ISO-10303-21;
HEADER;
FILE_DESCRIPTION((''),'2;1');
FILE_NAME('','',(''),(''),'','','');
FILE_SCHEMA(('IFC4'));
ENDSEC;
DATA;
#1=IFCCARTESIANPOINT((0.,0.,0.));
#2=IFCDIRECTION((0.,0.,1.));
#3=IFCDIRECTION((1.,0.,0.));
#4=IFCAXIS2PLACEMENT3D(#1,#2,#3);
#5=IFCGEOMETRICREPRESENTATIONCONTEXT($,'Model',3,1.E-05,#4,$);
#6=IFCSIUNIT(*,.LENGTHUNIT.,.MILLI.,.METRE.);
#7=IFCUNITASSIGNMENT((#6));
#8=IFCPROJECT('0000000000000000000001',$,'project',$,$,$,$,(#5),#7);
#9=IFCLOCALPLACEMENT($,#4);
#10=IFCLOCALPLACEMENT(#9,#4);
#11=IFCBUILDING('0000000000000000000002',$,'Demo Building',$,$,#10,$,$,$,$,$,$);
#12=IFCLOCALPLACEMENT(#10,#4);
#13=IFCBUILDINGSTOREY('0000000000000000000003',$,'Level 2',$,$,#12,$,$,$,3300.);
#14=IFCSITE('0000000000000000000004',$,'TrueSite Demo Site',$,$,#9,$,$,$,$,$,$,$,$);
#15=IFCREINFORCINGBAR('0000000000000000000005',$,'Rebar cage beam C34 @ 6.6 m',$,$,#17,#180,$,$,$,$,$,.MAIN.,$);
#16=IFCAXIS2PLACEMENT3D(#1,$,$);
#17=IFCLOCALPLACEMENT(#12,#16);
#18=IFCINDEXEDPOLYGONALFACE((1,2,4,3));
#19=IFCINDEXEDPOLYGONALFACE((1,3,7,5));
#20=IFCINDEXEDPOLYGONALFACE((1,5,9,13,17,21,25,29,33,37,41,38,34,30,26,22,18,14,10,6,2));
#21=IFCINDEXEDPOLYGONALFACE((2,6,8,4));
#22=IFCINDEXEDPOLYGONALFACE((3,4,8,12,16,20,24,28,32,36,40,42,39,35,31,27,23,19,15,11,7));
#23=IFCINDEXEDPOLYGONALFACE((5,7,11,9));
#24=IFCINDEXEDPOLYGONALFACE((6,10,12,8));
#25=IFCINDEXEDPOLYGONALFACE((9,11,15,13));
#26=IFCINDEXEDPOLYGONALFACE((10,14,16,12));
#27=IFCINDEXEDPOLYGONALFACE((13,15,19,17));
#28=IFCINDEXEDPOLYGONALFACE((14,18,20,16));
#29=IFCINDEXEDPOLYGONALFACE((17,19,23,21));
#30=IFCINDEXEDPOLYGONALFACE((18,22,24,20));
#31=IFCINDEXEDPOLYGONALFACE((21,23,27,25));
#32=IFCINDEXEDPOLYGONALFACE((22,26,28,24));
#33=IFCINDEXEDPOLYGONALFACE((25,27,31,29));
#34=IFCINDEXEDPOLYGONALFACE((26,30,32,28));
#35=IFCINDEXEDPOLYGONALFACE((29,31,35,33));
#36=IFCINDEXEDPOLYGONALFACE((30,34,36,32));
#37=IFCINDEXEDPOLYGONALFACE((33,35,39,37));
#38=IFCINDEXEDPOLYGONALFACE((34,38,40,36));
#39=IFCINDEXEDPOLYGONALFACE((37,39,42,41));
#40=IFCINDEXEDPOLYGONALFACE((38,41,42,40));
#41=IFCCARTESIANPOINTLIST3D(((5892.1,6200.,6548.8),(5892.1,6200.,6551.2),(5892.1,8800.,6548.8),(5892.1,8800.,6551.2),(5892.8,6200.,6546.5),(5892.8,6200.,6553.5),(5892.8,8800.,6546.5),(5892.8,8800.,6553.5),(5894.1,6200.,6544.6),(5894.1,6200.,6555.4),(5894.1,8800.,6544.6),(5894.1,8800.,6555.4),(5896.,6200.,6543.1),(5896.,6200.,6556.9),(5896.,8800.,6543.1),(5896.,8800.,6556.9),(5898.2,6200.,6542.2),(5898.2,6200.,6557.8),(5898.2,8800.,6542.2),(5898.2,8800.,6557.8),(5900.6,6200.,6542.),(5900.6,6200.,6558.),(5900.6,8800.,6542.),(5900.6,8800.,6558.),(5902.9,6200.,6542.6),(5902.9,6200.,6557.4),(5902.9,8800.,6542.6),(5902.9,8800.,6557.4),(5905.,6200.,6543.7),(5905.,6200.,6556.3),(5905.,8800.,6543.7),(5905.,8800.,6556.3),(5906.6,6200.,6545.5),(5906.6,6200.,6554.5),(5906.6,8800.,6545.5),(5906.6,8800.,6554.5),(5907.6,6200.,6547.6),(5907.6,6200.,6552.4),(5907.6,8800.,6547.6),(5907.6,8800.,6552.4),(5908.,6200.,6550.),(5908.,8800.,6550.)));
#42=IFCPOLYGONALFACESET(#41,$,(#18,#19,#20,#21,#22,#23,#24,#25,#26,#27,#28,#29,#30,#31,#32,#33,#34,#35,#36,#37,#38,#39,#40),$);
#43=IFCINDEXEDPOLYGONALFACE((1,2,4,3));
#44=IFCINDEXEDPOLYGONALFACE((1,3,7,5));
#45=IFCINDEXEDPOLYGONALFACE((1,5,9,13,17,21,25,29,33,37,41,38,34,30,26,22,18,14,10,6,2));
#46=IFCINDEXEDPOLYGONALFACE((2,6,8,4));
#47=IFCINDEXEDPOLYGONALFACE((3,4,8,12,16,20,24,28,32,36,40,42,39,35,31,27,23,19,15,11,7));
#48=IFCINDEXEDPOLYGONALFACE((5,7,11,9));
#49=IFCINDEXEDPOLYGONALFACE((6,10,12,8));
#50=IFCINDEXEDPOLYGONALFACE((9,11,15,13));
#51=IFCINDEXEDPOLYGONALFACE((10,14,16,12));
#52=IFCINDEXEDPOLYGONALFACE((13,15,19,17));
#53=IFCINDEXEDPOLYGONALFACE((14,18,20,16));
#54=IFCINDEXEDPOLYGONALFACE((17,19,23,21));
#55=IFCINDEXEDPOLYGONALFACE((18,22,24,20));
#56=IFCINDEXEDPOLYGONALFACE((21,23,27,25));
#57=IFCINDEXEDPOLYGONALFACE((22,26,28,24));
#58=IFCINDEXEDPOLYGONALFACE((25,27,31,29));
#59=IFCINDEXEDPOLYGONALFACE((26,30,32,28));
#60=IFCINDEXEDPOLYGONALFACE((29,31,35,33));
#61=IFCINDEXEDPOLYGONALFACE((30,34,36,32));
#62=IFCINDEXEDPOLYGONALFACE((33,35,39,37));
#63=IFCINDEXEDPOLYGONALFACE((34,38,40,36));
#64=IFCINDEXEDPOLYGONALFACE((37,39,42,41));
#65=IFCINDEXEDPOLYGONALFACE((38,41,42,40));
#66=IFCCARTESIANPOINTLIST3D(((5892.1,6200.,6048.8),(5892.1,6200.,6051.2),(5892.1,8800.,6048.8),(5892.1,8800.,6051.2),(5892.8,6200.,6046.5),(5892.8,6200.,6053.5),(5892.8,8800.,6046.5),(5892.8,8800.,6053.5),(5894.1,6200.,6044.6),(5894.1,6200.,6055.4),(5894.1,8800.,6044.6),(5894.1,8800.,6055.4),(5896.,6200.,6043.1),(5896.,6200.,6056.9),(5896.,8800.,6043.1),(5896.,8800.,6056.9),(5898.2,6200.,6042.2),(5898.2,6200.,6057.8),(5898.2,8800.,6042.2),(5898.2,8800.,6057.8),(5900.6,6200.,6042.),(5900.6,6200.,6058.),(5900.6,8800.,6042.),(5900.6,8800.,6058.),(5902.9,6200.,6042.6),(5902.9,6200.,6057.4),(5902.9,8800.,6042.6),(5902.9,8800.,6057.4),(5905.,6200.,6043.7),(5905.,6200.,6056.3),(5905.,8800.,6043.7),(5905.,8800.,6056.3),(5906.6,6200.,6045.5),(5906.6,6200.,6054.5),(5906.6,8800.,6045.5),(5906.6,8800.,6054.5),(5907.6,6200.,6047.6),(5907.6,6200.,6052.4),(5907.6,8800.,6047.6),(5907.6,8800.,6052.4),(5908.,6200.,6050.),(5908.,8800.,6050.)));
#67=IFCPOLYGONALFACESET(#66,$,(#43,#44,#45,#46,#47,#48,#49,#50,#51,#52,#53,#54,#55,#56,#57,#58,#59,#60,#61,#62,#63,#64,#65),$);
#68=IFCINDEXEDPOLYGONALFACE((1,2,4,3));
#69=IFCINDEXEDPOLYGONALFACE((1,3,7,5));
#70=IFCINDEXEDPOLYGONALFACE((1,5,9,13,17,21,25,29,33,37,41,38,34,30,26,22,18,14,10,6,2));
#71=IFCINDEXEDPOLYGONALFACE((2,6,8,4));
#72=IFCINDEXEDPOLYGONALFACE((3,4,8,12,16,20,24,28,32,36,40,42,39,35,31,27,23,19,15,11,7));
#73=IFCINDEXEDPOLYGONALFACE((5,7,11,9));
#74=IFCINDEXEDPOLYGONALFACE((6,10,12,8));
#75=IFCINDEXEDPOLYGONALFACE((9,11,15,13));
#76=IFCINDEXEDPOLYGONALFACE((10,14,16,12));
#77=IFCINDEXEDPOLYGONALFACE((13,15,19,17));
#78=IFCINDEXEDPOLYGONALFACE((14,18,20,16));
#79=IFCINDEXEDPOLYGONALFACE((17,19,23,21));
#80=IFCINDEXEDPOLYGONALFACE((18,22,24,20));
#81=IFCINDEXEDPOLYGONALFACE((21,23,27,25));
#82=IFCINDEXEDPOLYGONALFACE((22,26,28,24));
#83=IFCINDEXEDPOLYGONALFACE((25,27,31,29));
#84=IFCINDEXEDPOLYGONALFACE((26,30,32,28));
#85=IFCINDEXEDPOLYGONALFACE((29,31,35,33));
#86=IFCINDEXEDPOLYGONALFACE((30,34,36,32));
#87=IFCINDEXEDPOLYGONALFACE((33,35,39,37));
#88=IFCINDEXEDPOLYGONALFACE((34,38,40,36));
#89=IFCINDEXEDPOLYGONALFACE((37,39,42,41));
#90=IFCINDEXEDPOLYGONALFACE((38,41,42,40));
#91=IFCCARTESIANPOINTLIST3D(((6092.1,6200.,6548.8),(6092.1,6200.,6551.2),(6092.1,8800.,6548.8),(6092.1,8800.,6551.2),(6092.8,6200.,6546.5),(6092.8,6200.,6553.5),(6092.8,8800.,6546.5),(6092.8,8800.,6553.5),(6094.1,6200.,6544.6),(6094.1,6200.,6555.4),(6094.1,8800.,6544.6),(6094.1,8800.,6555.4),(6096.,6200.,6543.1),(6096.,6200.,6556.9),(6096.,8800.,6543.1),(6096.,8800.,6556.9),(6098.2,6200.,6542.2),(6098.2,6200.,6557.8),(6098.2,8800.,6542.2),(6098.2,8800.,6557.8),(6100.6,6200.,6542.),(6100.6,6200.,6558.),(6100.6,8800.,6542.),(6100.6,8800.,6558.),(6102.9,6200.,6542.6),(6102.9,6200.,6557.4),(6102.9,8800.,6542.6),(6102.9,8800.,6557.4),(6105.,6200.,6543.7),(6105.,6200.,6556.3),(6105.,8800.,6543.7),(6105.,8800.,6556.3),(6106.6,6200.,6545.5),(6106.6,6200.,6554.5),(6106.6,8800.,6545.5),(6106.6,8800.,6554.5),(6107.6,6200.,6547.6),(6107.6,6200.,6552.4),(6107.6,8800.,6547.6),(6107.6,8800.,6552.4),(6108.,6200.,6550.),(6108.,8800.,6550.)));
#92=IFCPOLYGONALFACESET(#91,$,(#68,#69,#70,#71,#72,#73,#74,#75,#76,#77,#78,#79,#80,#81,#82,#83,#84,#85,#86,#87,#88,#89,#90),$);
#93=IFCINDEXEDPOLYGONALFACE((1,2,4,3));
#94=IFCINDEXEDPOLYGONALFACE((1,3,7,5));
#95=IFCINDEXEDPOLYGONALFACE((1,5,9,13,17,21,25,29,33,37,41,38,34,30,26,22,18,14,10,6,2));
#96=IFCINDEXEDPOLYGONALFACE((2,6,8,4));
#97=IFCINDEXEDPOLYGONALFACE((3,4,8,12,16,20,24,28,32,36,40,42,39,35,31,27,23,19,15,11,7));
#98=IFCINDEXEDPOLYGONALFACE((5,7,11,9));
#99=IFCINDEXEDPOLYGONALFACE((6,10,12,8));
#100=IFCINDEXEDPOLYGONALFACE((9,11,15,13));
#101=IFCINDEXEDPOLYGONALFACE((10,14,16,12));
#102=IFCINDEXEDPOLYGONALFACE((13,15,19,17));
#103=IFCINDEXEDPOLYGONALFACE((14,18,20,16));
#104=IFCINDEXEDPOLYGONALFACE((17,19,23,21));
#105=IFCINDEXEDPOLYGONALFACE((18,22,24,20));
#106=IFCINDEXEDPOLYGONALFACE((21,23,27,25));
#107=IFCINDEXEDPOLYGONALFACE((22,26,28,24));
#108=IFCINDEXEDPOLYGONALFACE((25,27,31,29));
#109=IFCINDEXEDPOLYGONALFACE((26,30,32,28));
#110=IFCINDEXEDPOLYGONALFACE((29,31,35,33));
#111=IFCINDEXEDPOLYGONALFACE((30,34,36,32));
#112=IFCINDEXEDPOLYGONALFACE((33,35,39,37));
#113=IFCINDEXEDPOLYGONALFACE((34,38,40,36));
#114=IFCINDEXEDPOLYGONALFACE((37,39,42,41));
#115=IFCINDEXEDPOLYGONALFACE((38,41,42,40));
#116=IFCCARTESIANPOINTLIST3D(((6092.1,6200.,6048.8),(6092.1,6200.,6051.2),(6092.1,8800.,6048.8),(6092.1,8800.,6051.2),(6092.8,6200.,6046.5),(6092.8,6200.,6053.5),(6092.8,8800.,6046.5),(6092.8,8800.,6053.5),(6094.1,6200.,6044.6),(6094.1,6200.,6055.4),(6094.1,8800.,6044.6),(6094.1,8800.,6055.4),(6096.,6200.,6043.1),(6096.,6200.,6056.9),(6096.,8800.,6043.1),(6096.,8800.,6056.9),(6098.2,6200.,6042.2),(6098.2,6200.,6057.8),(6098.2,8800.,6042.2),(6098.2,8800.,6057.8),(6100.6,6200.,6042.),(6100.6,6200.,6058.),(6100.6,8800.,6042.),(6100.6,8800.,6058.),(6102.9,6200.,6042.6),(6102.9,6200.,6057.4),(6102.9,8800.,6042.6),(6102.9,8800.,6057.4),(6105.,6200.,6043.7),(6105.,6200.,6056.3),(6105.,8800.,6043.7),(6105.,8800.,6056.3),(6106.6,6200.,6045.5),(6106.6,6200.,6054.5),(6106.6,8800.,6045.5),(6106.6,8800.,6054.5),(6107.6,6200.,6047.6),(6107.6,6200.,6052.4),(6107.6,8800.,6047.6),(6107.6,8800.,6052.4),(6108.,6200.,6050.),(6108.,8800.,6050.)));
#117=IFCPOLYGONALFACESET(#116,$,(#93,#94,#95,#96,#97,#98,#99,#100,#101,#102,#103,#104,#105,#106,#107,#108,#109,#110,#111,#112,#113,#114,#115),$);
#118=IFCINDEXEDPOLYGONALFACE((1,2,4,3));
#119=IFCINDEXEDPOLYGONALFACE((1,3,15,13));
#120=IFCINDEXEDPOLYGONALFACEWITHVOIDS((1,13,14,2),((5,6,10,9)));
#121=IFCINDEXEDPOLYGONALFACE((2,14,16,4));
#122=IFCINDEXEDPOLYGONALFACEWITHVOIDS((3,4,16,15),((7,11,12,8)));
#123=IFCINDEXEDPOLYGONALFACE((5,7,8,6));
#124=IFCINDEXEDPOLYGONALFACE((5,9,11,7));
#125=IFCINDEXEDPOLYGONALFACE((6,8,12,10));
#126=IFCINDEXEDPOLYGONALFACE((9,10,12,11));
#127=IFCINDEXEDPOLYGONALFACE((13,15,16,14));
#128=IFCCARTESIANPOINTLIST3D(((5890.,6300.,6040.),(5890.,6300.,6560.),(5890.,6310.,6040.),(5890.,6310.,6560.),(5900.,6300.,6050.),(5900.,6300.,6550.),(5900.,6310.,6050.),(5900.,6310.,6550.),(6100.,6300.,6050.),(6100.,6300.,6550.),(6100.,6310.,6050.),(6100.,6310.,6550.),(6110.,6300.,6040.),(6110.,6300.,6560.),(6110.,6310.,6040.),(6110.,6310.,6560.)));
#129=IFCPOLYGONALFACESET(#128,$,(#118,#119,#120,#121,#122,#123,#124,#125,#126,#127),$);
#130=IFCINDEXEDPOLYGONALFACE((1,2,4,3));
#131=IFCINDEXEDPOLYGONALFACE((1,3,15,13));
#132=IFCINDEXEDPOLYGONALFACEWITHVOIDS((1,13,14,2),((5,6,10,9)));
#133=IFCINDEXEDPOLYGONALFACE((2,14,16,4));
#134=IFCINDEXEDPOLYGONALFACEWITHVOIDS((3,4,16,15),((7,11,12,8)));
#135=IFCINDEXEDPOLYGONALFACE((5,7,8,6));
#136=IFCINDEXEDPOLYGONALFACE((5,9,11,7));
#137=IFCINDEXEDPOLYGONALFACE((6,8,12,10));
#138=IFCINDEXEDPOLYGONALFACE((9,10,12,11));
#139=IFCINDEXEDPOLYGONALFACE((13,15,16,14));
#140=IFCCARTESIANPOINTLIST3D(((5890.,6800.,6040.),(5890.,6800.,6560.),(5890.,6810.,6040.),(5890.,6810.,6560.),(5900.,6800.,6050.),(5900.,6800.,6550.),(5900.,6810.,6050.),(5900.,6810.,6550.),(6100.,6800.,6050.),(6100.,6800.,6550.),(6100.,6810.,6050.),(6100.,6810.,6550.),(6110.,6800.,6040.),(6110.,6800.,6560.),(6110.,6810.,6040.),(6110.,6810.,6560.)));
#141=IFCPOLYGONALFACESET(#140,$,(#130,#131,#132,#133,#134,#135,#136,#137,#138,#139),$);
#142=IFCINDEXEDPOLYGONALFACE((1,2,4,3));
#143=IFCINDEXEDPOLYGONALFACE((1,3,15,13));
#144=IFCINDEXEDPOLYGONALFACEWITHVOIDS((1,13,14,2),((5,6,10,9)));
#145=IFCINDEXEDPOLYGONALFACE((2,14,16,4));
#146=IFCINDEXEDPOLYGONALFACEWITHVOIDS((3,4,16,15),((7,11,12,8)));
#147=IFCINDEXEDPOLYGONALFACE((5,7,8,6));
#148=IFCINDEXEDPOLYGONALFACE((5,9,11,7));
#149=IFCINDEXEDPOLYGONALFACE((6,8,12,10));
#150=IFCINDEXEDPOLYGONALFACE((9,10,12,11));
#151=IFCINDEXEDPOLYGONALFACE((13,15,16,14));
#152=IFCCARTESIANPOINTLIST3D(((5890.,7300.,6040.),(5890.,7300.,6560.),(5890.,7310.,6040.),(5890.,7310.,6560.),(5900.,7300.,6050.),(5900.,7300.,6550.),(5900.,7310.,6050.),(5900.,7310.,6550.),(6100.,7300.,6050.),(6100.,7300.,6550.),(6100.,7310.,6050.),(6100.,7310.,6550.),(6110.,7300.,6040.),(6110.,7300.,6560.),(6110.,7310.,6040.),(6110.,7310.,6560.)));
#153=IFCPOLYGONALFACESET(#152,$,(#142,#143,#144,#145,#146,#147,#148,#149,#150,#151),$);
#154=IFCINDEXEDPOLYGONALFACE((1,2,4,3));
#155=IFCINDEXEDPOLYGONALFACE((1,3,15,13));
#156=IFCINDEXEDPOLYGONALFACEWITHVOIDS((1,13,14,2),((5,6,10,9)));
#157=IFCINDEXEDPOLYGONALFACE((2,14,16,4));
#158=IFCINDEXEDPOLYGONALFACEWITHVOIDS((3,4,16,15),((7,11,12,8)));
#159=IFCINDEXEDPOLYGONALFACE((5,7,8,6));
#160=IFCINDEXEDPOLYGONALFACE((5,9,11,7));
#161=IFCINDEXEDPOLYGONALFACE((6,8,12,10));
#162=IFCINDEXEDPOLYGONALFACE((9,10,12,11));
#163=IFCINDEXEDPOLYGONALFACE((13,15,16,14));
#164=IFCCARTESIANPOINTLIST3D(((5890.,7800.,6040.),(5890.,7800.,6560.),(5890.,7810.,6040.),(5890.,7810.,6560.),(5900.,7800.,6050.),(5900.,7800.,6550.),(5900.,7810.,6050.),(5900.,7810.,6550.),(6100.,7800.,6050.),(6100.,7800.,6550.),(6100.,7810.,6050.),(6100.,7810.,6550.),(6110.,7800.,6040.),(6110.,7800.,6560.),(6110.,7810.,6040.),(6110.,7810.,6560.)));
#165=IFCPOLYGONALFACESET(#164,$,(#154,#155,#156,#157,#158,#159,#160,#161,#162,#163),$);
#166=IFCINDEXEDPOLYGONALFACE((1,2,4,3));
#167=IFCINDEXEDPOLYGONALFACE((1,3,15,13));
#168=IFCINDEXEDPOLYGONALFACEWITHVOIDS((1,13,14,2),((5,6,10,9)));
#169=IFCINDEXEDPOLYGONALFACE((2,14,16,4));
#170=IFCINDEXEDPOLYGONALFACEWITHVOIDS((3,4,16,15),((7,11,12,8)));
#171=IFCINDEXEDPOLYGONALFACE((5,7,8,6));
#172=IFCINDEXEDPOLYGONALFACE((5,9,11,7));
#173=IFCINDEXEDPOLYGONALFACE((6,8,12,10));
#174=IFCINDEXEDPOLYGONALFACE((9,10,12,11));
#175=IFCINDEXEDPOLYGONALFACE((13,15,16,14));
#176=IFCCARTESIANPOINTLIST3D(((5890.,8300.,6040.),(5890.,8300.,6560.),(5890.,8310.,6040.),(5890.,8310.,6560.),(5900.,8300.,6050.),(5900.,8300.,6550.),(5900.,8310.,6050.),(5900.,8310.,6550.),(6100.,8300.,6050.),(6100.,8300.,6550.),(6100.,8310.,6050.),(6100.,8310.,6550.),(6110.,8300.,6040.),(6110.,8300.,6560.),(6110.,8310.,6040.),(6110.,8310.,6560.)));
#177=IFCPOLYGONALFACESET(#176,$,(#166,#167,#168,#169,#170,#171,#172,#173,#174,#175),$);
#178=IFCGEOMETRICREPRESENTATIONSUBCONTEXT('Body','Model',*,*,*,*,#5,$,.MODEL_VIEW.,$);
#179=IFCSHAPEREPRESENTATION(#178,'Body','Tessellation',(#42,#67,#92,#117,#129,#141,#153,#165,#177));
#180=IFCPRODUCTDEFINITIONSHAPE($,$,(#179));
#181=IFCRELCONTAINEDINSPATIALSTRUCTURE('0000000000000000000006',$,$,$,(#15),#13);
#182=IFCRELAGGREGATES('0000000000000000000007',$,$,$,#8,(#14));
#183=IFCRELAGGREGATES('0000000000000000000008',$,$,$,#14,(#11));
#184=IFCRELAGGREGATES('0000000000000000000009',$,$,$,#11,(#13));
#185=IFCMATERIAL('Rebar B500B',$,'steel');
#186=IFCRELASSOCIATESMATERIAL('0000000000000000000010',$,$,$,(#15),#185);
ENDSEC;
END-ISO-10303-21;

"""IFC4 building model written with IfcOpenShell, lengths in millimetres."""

from ifc_helpers import new_model, si_unit, frame, origin_with_axes, place, context, subcontext, project, spatial, hollow_rectangle, circle, extrude, material, element, save


model = new_model("IFC4")

# Units and contexts
model_context = context("Model", 3, precision=1e-05, world=origin_with_axes())
body_context = subcontext(model_context, "Body", "Model", "MODEL_VIEW")
ifc_project = project(units=[si_unit("LENGTHUNIT", "METRE", prefix="MILLI")], contexts=[model_context])

# Site, building, storey
site_placement = place(None, origin_with_axes())
site = spatial("IfcSite", under=ifc_project, at=site_placement, Name="TrueSite Demo Site")
building_placement = place(site_placement, origin_with_axes())
building = spatial("IfcBuilding", under=site, at=building_placement, Name="Demo Building")
storey_placement = place(building_placement, origin_with_axes())
storey = spatial("IfcBuildingStorey", under=building, at=storey_placement, Name="Level 2", Elevation=3300.0)

# Reinforcing bar
ifc_material_1 = material(Name="Rebar B500B", Category="steel")
for number, where, z_axis, x_axis, name in (
    (1, (6000.0, 6200.0, 6300.0), (0.0, 1.0, 0.0), (1.0, 0.0, 0.0), "Rebar cage beam C34 @ 6.6 m"),
):
    element("IfcReinforcingBar", number, at=place(storey_placement, frame(where, z_axis=z_axis, x_axis=x_axis)), inside=storey, material=ifc_material_1, Name=name, PredefinedType="MAIN", context=body_context, shape_type="SweptSolid", body=[
        extrude(circle(Radius=8.0), frame((-100.0, -250.0, 0.0)), (0.0, 0.0, 1.0), 2600.0),
        extrude(circle(Radius=8.0), frame((-100.0, 250.0, 0.0)), (0.0, 0.0, 1.0), 2600.0),
        extrude(circle(Radius=8.0), frame((100.0, -250.0, 0.0)), (0.0, 0.0, 1.0), 2600.0),
        extrude(circle(Radius=8.0), frame((100.0, 250.0, 0.0)), (0.0, 0.0, 1.0), 2600.0),
        extrude(hollow_rectangle(XDim=220.0, YDim=520.0, WallThickness=10.0), frame((0.0, 0.0, 100.0)), (0.0, 0.0, 1.0), 10.0),
        extrude(hollow_rectangle(XDim=220.0, YDim=520.0, WallThickness=10.0), frame((0.0, 0.0, 600.0)), (0.0, 0.0, 1.0), 10.0),
        extrude(hollow_rectangle(XDim=220.0, YDim=520.0, WallThickness=10.0), frame((0.0, 0.0, 1100.0)), (0.0, 0.0, 1.0), 10.0),
        extrude(hollow_rectangle(XDim=220.0, YDim=520.0, WallThickness=10.0), frame((0.0, 0.0, 1600.0)), (0.0, 0.0, 1.0), 10.0),
        extrude(hollow_rectangle(XDim=220.0, YDim=520.0, WallThickness=10.0), frame((0.0, 0.0, 2100.0)), (0.0, 0.0, 1.0), 10.0),
    ])

save(model, "model.ifc")
